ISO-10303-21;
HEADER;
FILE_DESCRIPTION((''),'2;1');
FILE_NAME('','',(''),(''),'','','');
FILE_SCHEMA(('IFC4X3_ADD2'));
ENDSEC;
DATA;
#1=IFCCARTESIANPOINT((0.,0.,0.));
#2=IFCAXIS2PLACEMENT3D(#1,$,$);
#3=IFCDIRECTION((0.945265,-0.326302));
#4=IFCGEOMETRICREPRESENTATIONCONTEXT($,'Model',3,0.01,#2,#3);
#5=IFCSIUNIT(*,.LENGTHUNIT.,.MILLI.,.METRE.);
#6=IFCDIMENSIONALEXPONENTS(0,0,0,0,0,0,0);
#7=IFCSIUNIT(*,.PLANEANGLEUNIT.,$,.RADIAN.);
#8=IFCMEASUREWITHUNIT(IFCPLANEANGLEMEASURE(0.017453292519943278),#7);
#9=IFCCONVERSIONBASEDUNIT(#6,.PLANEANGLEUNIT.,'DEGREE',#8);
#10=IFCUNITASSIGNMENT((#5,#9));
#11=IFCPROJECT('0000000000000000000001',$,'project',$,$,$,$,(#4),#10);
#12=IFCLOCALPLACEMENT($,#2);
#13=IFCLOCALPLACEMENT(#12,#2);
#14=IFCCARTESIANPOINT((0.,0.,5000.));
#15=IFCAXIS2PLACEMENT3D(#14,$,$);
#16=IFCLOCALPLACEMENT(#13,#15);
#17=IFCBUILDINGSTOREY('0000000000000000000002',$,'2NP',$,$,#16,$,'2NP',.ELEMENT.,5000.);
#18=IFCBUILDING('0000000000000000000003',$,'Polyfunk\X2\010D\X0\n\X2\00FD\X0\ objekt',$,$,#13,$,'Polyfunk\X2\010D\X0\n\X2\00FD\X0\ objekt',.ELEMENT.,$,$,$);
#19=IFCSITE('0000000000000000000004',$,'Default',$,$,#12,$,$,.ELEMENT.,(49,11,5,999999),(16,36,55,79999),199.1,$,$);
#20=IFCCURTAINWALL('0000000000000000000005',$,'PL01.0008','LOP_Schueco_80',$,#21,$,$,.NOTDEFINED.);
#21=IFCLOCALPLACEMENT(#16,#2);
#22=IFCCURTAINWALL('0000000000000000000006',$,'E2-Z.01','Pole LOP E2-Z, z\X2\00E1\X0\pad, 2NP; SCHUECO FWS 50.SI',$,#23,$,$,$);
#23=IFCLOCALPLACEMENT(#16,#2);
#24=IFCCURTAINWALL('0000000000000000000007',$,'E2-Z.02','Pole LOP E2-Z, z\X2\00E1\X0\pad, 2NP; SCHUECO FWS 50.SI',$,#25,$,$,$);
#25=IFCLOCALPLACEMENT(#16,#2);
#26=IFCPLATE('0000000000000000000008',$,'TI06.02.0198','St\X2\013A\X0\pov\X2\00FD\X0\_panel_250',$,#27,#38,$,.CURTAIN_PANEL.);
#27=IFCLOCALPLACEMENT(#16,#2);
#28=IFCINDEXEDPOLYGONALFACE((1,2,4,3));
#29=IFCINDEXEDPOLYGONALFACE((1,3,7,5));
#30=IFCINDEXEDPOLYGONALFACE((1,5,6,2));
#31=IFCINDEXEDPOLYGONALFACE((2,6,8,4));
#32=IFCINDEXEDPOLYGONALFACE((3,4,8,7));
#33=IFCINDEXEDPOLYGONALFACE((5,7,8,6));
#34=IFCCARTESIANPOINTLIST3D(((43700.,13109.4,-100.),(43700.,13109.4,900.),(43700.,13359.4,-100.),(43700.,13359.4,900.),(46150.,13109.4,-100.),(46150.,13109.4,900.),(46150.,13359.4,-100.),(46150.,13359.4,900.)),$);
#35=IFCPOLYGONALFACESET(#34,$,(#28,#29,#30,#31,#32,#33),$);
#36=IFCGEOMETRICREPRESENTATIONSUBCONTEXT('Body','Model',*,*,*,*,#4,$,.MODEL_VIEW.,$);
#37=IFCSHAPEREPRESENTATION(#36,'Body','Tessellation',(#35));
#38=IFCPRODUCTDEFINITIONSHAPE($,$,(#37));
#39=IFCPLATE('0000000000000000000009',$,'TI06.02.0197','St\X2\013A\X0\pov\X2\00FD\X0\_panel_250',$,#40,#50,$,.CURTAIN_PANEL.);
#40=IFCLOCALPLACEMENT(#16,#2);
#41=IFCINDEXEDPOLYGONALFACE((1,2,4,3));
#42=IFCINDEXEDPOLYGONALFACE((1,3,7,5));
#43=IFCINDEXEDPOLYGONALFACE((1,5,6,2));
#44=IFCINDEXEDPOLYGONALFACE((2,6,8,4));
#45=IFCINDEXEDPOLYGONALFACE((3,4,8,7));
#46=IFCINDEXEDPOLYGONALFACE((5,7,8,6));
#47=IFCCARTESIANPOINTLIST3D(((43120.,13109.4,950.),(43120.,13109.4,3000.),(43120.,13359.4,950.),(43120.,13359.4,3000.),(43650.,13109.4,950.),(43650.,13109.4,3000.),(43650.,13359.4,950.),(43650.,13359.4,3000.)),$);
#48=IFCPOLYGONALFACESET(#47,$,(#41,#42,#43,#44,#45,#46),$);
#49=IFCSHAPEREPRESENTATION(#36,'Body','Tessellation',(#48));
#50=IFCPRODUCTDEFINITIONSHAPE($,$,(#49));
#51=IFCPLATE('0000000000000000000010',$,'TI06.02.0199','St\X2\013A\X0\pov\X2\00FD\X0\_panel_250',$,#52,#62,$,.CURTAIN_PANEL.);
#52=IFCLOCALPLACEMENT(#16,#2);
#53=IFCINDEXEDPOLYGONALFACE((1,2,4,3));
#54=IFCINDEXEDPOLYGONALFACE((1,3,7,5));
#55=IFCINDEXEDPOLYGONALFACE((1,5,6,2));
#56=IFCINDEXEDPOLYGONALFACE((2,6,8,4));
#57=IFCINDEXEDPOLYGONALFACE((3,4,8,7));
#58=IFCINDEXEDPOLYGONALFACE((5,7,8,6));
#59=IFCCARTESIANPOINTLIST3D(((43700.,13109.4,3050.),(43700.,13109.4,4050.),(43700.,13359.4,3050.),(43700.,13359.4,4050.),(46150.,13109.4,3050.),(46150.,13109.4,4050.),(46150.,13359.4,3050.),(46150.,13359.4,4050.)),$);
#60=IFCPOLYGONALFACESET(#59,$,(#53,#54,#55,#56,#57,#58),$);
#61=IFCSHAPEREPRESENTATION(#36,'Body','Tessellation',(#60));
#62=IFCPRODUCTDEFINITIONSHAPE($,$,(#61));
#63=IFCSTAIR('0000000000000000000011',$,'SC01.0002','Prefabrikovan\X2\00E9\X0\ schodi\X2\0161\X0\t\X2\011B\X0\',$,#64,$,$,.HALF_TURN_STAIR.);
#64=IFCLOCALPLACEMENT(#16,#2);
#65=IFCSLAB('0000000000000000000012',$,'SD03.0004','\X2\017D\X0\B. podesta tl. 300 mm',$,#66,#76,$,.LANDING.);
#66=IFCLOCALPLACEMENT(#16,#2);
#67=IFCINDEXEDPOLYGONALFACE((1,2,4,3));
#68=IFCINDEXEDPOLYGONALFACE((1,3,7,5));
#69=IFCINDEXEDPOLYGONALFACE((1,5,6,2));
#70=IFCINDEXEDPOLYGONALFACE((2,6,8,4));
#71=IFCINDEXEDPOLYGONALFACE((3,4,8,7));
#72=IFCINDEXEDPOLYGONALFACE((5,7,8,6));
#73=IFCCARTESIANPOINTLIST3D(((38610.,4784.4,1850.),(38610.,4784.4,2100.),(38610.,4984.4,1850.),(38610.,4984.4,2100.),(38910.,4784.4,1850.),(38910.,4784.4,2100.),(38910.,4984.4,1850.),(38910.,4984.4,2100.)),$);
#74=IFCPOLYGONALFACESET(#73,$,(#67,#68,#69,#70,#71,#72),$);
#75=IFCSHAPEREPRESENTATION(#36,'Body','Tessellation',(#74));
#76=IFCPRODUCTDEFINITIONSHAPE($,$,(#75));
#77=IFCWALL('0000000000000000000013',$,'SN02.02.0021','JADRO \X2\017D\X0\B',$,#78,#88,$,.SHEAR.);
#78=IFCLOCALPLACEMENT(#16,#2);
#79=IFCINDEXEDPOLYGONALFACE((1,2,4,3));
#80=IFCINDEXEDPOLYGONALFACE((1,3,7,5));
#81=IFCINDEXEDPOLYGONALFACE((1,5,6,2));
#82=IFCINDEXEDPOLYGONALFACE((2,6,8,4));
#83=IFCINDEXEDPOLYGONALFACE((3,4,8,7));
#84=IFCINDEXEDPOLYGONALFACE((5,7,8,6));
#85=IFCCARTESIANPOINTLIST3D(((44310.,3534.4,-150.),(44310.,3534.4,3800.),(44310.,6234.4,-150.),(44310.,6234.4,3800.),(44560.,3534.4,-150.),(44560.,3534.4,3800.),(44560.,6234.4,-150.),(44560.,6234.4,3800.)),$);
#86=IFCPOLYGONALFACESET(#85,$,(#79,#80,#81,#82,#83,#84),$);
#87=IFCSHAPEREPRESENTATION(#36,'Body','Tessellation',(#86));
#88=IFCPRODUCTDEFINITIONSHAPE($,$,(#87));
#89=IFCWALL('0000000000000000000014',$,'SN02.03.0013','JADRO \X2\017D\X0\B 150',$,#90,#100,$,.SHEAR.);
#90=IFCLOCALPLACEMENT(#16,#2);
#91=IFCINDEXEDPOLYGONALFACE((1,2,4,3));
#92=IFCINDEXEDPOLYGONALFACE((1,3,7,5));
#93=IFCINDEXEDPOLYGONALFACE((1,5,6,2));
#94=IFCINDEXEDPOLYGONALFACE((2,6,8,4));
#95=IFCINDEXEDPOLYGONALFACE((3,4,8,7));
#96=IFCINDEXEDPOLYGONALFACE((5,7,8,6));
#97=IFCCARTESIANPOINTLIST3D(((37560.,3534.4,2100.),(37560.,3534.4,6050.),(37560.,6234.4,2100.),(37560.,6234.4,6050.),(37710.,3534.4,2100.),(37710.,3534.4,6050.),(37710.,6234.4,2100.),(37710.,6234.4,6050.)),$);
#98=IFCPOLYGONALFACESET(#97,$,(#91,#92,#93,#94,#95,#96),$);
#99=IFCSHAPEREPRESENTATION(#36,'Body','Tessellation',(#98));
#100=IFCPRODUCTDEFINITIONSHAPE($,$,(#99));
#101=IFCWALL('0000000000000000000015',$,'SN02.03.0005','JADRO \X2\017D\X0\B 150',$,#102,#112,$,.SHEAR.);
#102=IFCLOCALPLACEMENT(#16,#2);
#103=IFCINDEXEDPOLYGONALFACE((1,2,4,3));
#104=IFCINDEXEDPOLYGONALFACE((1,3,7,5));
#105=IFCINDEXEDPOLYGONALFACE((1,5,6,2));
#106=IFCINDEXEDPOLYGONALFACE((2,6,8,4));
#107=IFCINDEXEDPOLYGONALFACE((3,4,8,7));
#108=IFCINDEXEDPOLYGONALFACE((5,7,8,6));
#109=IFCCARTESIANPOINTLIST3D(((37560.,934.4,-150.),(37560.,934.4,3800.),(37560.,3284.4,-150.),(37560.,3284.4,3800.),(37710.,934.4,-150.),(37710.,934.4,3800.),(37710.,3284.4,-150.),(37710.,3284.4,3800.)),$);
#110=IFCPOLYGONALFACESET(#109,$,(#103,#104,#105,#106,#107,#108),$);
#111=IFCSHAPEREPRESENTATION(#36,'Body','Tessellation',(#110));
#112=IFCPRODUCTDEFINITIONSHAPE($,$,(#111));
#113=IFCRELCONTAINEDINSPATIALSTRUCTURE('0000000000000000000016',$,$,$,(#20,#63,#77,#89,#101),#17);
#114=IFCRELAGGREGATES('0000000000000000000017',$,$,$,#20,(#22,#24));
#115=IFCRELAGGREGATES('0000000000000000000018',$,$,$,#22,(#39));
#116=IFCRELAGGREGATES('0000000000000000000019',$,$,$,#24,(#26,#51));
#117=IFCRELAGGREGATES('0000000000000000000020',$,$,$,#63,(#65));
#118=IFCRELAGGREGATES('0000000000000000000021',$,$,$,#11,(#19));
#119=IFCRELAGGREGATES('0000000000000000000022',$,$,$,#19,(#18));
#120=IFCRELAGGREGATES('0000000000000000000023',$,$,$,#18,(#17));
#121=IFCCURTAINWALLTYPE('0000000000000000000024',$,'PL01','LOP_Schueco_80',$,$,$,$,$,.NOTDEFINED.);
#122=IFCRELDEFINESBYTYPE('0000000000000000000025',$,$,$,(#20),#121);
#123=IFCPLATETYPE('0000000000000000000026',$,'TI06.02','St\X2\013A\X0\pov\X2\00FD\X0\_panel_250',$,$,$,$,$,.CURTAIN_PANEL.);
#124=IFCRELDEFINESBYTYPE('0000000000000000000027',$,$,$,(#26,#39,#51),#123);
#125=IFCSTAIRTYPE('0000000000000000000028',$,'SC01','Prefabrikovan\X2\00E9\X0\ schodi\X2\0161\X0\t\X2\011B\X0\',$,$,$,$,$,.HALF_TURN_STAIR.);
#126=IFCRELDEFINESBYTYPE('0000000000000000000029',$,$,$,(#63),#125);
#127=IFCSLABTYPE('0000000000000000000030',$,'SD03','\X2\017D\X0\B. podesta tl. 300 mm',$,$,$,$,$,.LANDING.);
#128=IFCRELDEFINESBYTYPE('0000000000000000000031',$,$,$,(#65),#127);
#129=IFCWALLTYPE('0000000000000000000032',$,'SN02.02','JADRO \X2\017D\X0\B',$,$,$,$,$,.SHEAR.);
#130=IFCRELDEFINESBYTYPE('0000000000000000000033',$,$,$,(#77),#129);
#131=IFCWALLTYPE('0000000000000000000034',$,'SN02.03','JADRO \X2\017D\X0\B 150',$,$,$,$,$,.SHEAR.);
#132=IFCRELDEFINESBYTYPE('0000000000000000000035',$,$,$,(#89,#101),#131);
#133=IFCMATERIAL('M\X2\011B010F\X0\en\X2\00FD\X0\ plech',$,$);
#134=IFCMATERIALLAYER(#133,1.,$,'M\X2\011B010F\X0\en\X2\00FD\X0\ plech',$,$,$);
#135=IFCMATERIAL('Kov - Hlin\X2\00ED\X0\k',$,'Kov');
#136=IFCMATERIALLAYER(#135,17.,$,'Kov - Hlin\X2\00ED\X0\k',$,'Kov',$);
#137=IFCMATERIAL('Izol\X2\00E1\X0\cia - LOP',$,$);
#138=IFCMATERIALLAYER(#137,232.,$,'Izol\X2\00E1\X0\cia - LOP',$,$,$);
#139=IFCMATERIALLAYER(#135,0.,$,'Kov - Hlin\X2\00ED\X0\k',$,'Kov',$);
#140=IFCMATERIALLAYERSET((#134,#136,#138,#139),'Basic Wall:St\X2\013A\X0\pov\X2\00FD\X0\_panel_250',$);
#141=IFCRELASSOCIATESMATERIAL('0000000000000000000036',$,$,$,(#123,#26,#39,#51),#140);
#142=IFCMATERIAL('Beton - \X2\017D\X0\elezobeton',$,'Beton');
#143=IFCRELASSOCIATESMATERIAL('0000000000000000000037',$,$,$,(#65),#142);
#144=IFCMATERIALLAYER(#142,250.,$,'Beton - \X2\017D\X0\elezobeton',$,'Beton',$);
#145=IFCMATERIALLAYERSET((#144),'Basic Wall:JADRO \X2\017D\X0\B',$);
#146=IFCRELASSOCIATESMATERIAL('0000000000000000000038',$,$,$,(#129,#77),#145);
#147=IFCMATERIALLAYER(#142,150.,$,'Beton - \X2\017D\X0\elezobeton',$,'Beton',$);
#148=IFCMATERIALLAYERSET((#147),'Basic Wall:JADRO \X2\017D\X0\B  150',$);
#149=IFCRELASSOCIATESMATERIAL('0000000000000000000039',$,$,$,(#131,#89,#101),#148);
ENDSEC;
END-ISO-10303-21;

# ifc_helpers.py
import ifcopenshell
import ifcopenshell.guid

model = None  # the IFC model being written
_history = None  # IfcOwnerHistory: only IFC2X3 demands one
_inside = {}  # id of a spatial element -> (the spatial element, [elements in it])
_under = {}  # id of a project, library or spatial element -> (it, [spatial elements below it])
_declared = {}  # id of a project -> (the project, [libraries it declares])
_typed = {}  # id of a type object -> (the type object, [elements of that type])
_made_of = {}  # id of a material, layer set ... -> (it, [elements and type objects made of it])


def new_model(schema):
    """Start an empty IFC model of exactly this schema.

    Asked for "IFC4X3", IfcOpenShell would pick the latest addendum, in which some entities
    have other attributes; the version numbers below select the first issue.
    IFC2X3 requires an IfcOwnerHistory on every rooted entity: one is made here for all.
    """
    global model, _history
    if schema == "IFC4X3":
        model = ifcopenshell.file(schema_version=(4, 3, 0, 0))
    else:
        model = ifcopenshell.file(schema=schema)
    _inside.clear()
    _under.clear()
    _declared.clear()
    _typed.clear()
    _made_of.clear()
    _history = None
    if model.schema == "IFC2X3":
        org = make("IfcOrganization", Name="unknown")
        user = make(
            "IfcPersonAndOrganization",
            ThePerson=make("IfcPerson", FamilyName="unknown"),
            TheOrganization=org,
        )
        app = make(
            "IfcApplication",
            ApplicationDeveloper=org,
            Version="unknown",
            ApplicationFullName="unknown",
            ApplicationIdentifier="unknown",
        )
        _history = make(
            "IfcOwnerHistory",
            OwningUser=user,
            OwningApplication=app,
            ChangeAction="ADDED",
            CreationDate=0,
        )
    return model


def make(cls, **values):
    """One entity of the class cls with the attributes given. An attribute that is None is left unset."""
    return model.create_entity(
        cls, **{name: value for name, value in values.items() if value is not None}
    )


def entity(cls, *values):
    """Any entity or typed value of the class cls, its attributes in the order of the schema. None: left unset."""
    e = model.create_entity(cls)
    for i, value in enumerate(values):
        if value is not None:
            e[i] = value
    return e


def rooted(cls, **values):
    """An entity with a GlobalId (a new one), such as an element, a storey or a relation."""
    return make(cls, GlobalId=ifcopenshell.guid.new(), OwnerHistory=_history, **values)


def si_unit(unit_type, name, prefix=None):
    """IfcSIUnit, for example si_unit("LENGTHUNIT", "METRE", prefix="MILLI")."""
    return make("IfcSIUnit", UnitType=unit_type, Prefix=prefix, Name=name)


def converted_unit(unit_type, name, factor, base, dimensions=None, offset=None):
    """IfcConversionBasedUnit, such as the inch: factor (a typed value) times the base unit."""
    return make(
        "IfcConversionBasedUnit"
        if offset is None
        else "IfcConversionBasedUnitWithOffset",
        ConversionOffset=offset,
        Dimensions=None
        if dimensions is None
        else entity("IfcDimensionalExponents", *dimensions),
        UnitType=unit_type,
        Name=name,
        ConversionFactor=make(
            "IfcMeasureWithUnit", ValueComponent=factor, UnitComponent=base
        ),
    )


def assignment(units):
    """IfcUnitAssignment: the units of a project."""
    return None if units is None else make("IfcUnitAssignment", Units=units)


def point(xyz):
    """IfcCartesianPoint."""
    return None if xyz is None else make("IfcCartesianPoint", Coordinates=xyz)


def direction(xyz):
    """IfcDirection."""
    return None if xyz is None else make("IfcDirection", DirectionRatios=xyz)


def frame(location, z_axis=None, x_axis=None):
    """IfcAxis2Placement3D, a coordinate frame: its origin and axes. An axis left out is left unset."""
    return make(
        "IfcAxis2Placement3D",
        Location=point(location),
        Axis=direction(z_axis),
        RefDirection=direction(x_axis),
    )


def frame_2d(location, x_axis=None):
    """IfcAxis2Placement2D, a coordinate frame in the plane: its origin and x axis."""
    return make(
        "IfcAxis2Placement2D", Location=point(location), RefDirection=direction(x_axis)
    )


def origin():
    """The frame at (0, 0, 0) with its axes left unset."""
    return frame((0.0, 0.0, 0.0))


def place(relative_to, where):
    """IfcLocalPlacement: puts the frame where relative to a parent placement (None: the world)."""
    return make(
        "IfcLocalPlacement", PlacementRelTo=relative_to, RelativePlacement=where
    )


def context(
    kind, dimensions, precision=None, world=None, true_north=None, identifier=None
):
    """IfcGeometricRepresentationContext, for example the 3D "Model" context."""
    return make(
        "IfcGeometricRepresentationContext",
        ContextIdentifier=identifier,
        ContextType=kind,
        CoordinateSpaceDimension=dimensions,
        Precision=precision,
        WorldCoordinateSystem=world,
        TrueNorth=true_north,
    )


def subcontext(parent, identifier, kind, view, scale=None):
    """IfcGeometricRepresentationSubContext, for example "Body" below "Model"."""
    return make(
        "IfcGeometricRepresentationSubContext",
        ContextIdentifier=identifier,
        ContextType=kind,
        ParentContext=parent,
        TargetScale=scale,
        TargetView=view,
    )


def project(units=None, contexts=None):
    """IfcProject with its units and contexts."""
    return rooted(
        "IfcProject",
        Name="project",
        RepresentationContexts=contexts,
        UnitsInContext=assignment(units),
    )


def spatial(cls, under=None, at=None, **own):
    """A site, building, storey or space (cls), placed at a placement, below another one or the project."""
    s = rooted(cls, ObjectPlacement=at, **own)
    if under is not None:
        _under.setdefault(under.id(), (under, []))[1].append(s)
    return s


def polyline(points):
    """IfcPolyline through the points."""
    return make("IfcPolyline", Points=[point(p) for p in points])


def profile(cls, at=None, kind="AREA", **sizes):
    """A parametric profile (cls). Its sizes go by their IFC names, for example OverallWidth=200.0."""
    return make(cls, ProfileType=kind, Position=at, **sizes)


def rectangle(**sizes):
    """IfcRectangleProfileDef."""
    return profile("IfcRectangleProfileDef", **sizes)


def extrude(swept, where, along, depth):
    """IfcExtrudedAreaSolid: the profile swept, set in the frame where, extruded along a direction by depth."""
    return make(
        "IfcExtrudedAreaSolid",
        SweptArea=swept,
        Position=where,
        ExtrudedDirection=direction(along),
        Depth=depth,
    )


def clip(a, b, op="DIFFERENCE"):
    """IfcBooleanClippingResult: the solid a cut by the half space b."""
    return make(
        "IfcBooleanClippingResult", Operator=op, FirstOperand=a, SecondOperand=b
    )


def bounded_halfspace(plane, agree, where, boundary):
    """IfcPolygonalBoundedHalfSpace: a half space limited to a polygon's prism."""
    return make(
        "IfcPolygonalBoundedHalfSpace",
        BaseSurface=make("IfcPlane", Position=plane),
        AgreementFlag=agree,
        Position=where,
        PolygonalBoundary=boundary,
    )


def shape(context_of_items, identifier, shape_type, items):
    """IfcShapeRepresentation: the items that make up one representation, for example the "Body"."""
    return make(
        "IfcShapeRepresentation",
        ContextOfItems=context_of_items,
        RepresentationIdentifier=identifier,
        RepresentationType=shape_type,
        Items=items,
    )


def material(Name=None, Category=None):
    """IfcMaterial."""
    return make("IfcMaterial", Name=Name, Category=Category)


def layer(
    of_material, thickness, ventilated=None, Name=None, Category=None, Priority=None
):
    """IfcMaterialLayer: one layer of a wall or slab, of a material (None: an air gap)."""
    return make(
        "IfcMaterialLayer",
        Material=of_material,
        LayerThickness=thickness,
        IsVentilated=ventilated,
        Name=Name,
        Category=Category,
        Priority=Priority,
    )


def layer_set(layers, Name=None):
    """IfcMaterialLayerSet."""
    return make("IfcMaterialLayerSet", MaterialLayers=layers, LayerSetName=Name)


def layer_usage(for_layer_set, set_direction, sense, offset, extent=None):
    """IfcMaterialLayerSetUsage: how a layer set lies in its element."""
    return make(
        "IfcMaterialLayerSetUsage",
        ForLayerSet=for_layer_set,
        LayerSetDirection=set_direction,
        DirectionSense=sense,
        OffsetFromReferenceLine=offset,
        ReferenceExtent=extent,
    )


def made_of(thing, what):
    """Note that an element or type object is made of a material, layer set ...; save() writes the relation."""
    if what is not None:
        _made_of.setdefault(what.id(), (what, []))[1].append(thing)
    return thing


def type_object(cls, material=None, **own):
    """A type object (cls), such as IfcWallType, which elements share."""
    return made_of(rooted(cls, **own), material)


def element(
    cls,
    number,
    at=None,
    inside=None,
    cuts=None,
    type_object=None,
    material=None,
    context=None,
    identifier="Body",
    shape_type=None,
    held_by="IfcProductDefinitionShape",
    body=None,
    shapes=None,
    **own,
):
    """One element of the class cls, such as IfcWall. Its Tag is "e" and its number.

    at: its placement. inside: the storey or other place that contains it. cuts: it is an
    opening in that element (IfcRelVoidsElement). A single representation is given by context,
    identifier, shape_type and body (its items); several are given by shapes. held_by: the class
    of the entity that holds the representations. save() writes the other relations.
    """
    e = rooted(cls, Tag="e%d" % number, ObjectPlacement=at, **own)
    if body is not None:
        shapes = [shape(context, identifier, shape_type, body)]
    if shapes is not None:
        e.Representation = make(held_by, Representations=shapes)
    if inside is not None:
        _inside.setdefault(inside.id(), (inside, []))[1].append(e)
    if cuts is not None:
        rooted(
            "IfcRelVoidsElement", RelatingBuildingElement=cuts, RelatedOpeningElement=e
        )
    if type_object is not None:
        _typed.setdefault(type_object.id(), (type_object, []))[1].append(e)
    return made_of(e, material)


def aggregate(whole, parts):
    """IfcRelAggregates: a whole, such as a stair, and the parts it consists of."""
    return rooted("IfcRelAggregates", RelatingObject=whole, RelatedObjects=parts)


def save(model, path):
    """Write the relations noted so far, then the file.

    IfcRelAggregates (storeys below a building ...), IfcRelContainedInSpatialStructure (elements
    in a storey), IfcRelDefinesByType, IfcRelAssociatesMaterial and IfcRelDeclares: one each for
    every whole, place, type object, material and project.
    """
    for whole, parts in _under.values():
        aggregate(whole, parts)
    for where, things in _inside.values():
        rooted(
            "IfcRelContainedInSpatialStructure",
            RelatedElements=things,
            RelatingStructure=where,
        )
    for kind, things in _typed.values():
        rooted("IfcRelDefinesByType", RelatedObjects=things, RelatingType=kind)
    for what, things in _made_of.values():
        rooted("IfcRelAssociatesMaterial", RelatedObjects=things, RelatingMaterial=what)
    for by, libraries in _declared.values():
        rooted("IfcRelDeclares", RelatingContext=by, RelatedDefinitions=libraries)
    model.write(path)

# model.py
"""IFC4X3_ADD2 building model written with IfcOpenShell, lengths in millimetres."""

from ifc_helpers import new_model, entity, si_unit, converted_unit, direction, frame, frame_2d, origin, place, context, subcontext, project, spatial, polyline, rectangle, extrude, clip, bounded_halfspace, material, layer, layer_set, layer_usage, type_object, element, aggregate, save


model = new_model("IFC4X3_ADD2")

# Units and contexts
model_context = context("Model", 3, precision=0.01, world=origin(), true_north=direction((0.945265, -0.326302)))
body_context = subcontext(model_context, "Body", "Model", "MODEL_VIEW")
ifc_project = project(units=[si_unit("LENGTHUNIT", "METRE", prefix="MILLI"), converted_unit("PLANEANGLEUNIT", "DEGREE", entity("IfcPlaneAngleMeasure", 0.017453292519943278), si_unit("PLANEANGLEUNIT", "RADIAN"), dimensions=[0, 0, 0, 0, 0, 0, 0])], contexts=[model_context])

# Site, building, storey
site_placement = place(None, origin())
site = spatial("IfcSite", under=ifc_project, at=site_placement, Name="Default", CompositionType="ELEMENT", RefLatitude=(49, 11, 5, 999999), RefLongitude=(16, 36, 55, 79999), RefElevation=199.1)
building_placement = place(site_placement, origin())
building = spatial("IfcBuilding", under=site, at=building_placement, Name="Polyfunkčný objekt", LongName="Polyfunkčný objekt", CompositionType="ELEMENT")
storey_placement = place(building_placement, frame((0.0, 0.0, 5000.0)))
storey = spatial("IfcBuildingStorey", under=building, at=storey_placement, Name="2NP", LongName="2NP", CompositionType="ELEMENT", Elevation=5000.0)

# Curtain walls, plates
curtain_wall_type = type_object("IfcCurtainWallType", Name="PL01", Description="LOP_Schueco_80", PredefinedType="NOTDEFINED")
curtain_wall_1_placement = place(storey_placement, frame((0.0, 0.0, -5000.0)))
curtain_wall_1 = element("IfcCurtainWall", 1, at=curtain_wall_1_placement, inside=storey, type_object=curtain_wall_type, Name="PL01.0008", Description="LOP_Schueco_80", PredefinedType="NOTDEFINED")
curtain_wall_2 = element("IfcCurtainWall", 2, Name="E2-Z.01", Description="Pole LOP E2-Z, západ, 2NP; SCHUECO FWS 50.SI")
curtain_wall_3 = element("IfcCurtainWall", 3, Name="E2-Z.02", Description="Pole LOP E2-Z, západ, 2NP; SCHUECO FWS 50.SI")
aggregate(curtain_wall_1, [curtain_wall_2, curtain_wall_3])
ifc_material_1 = material(Name="Měďený plech")
ifc_layer_1 = layer(ifc_material_1, 1.0, Name="Měďený plech")
ifc_material_2 = material(Name="Kov - Hliník", Category="Kov")
ifc_layer_2 = layer(ifc_material_2, 17.0, Name="Kov - Hliník", Category="Kov")
ifc_material_3 = material(Name="Izolácia - LOP")
ifc_layer_3 = layer(ifc_material_3, 232.0, Name="Izolácia - LOP")
ifc_layer_4 = layer(ifc_material_2, 0.0, Name="Kov - Hliník", Category="Kov")
ifc_layer_set_1 = layer_set([ifc_layer_1, ifc_layer_2, ifc_layer_3, ifc_layer_4], Name="Basic Wall:Stĺpový_panel_250")
ifc_layer_usage_1 = layer_usage(ifc_layer_set_1, "AXIS2", "NEGATIVE", 125.0)
plate_type = type_object("IfcPlateType", Name="TI06.02", Description="Stĺpový_panel_250", PredefinedType="CURTAIN_PANEL", material=ifc_layer_set_1)
plate_1_placement = place(storey_placement, frame((43700.0, 13234.4, -100.0)))
plate_1 = element("IfcPlate", 4, at=plate_1_placement, type_object=plate_type, material=ifc_layer_usage_1, Name="TI06.02.0198", Description="Stĺpový_panel_250", PredefinedType="CURTAIN_PANEL", context=body_context, shape_type="SweptSolid", body=[
    extrude(rectangle(XDim=250.0, YDim=2450.0, at=frame_2d((0.0, 0.0), x_axis=(1.0, 0.0))), frame((1225.0, 0.0, 0.0), z_axis=(0.0, 0.0, 1.0), x_axis=(0.0, 1.0, 0.0)), (0.0, 0.0, 1.0), 1000.0),
])
ifc_layer_usage_2 = layer_usage(ifc_layer_set_1, "AXIS2", "NEGATIVE", 125.0)
plate_2_placement = place(storey_placement, frame((43120.0, 13234.4, 950.0)))
plate_2 = element("IfcPlate", 5, at=plate_2_placement, type_object=plate_type, material=ifc_layer_usage_2, Name="TI06.02.0197", Description="Stĺpový_panel_250", PredefinedType="CURTAIN_PANEL", context=body_context, shape_type="SweptSolid", body=[
    extrude(rectangle(XDim=250.0, YDim=530.0, at=frame_2d((0.0, 0.0), x_axis=(1.0, 0.0))), frame((265.0, 0.0, 0.0), z_axis=(0.0, 0.0, 1.0), x_axis=(0.0, 1.0, 0.0)), (0.0, 0.0, 1.0), 2050.0),
])
aggregate(curtain_wall_2, [plate_2])
ifc_layer_usage_3 = layer_usage(ifc_layer_set_1, "AXIS2", "NEGATIVE", 125.0)
plate_3_placement = place(storey_placement, frame((43700.0, 13234.4, 3050.0)))
plate_3 = element("IfcPlate", 6, at=plate_3_placement, type_object=plate_type, material=ifc_layer_usage_3, Name="TI06.02.0199", Description="Stĺpový_panel_250", PredefinedType="CURTAIN_PANEL", context=body_context, shape_type="SweptSolid", body=[
    extrude(rectangle(XDim=250.0, YDim=2450.0, at=frame_2d((0.0, 0.0), x_axis=(1.0, 0.0))), frame((1225.0, 0.0, 0.0), z_axis=(0.0, 0.0, 1.0), x_axis=(0.0, 1.0, 0.0)), (0.0, 0.0, 1.0), 1000.0),
])
aggregate(curtain_wall_3, [plate_1, plate_3])

# Stair, slab
stair_type = type_object("IfcStairType", Name="SC01", Description="Prefabrikované schodiště", PredefinedType="HALF_TURN_STAIR")
stair_placement = place(storey_placement, origin())
stair = element("IfcStair", 7, at=stair_placement, inside=storey, type_object=stair_type, Name="SC01.0002", Description="Prefabrikované schodiště", PredefinedType="HALF_TURN_STAIR")
ifc_material_4 = material(Name="Beton - Železobeton", Category="Beton")
slab_type = type_object("IfcSlabType", Name="SD03", Description="ŽB. podesta tl. 300 mm", PredefinedType="LANDING")
slab_placement = place(stair_placement, frame((38610.0, 4784.4, 0.0)))
slab = element("IfcSlab", 8, at=slab_placement, type_object=slab_type, material=ifc_material_4, Name="SD03.0004", Description="ŽB. podesta tl. 300 mm", PredefinedType="LANDING", context=body_context, shape_type="SweptSolid", body=[
    extrude(rectangle(XDim=200.0, YDim=300.0, at=frame_2d((0.0, 0.0), x_axis=(1.0, 0.0))), frame((150.0, 100.0, 1850.0), z_axis=(0.0, 0.0, 1.0), x_axis=(0.0, 1.0, 0.0)), (0.0, 0.0, 1.0), 250.0),
])
aggregate(stair, [slab])

# Walls
ifc_layer_5 = layer(ifc_material_4, 250.0, Name="Beton - Železobeton", Category="Beton")
ifc_layer_set_2 = layer_set([ifc_layer_5], Name="Basic Wall:JADRO ŽB")
wall_type_1 = type_object("IfcWallType", Name="SN02.02", Description="JADRO ŽB", PredefinedType="SHEAR", material=ifc_layer_set_2)
placement = place(building_placement, origin())
wall_1_placement = place(placement, frame((44435.0, 6234.4, 4850.0), z_axis=(0.0, 0.0, 1.0), x_axis=(0.0, -1.0, 0.0)))
element("IfcWall", 9, at=wall_1_placement, inside=storey, type_object=wall_type_1, material=ifc_layer_set_2, Name="SN02.02.0021", Description="JADRO ŽB", PredefinedType="SHEAR", context=body_context, shape_type="Clipping", body=[
    clip(clip(extrude(rectangle(XDim=2700.0, YDim=250.0, at=frame_2d((1350.0, 0.0), x_axis=(-1.0, 0.0))), origin(), (0.0, 0.0, 1.0), 3950.0), bounded_halfspace(frame((2700.0, -125.0, 0.0), z_axis=(0.0, 0.0, 1.0), x_axis=(0.0, -1.0, 0.0)), True, frame((2700.0, -125.0, 0.0)), polyline([(0.0, 0.0), (0.0, 250.0), (-2700.0, 250.0), (-2700.0, 0.0), (0.0, 0.0)]))), bounded_halfspace(frame((0.0, -125.0, 3950.0), z_axis=(0.0, 0.0, -1.0), x_axis=(0.0, 1.0, 0.0)), True, frame((0.0, -125.0, 3950.0)), polyline([(0.0, 0.0), (2700.0, 0.0), (2700.0, 250.0), (0.0, 250.0), (0.0, 0.0)]))),
])
ifc_layer_6 = layer(ifc_material_4, 150.0, Name="Beton - Železobeton", Category="Beton")
ifc_layer_set_3 = layer_set([ifc_layer_6], Name="Basic Wall:JADRO ŽB  150")
wall_type_2 = type_object("IfcWallType", Name="SN02.03", Description="JADRO ŽB 150", PredefinedType="SHEAR", material=ifc_layer_set_3)
wall_2_placement = place(storey_placement, frame((37635.0, 6234.4, 2100.0), z_axis=(0.0, 0.0, 1.0), x_axis=(0.0, -1.0, 0.0)))
element("IfcWall", 10, at=wall_2_placement, inside=storey, type_object=wall_type_2, material=ifc_layer_set_3, Name="SN02.03.0013", Description="JADRO ŽB 150", PredefinedType="SHEAR", context=body_context, shape_type="SweptSolid", body=[
    extrude(rectangle(XDim=2700.0, YDim=150.0, at=frame_2d((1350.0, 0.0), x_axis=(-1.0, 0.0))), origin(), (0.0, 0.0, 1.0), 3950.0),
])
wall_3_placement = place(placement, frame((37635.0, 3284.4, 4850.0), z_axis=(0.0, 0.0, 1.0), x_axis=(0.0, -1.0, 0.0)))
element("IfcWall", 11, at=wall_3_placement, inside=storey, type_object=wall_type_2, material=ifc_layer_set_3, Name="SN02.03.0005", Description="JADRO ŽB 150", PredefinedType="SHEAR", context=body_context, shape_type="SweptSolid", body=[
    extrude(rectangle(XDim=2350.0, YDim=150.0, at=frame_2d((1175.0, 0.0), x_axis=(-1.0, 0.0))), origin(), (0.0, 0.0, 1.0), 3950.0),
])

save(model, "model.ifc")
